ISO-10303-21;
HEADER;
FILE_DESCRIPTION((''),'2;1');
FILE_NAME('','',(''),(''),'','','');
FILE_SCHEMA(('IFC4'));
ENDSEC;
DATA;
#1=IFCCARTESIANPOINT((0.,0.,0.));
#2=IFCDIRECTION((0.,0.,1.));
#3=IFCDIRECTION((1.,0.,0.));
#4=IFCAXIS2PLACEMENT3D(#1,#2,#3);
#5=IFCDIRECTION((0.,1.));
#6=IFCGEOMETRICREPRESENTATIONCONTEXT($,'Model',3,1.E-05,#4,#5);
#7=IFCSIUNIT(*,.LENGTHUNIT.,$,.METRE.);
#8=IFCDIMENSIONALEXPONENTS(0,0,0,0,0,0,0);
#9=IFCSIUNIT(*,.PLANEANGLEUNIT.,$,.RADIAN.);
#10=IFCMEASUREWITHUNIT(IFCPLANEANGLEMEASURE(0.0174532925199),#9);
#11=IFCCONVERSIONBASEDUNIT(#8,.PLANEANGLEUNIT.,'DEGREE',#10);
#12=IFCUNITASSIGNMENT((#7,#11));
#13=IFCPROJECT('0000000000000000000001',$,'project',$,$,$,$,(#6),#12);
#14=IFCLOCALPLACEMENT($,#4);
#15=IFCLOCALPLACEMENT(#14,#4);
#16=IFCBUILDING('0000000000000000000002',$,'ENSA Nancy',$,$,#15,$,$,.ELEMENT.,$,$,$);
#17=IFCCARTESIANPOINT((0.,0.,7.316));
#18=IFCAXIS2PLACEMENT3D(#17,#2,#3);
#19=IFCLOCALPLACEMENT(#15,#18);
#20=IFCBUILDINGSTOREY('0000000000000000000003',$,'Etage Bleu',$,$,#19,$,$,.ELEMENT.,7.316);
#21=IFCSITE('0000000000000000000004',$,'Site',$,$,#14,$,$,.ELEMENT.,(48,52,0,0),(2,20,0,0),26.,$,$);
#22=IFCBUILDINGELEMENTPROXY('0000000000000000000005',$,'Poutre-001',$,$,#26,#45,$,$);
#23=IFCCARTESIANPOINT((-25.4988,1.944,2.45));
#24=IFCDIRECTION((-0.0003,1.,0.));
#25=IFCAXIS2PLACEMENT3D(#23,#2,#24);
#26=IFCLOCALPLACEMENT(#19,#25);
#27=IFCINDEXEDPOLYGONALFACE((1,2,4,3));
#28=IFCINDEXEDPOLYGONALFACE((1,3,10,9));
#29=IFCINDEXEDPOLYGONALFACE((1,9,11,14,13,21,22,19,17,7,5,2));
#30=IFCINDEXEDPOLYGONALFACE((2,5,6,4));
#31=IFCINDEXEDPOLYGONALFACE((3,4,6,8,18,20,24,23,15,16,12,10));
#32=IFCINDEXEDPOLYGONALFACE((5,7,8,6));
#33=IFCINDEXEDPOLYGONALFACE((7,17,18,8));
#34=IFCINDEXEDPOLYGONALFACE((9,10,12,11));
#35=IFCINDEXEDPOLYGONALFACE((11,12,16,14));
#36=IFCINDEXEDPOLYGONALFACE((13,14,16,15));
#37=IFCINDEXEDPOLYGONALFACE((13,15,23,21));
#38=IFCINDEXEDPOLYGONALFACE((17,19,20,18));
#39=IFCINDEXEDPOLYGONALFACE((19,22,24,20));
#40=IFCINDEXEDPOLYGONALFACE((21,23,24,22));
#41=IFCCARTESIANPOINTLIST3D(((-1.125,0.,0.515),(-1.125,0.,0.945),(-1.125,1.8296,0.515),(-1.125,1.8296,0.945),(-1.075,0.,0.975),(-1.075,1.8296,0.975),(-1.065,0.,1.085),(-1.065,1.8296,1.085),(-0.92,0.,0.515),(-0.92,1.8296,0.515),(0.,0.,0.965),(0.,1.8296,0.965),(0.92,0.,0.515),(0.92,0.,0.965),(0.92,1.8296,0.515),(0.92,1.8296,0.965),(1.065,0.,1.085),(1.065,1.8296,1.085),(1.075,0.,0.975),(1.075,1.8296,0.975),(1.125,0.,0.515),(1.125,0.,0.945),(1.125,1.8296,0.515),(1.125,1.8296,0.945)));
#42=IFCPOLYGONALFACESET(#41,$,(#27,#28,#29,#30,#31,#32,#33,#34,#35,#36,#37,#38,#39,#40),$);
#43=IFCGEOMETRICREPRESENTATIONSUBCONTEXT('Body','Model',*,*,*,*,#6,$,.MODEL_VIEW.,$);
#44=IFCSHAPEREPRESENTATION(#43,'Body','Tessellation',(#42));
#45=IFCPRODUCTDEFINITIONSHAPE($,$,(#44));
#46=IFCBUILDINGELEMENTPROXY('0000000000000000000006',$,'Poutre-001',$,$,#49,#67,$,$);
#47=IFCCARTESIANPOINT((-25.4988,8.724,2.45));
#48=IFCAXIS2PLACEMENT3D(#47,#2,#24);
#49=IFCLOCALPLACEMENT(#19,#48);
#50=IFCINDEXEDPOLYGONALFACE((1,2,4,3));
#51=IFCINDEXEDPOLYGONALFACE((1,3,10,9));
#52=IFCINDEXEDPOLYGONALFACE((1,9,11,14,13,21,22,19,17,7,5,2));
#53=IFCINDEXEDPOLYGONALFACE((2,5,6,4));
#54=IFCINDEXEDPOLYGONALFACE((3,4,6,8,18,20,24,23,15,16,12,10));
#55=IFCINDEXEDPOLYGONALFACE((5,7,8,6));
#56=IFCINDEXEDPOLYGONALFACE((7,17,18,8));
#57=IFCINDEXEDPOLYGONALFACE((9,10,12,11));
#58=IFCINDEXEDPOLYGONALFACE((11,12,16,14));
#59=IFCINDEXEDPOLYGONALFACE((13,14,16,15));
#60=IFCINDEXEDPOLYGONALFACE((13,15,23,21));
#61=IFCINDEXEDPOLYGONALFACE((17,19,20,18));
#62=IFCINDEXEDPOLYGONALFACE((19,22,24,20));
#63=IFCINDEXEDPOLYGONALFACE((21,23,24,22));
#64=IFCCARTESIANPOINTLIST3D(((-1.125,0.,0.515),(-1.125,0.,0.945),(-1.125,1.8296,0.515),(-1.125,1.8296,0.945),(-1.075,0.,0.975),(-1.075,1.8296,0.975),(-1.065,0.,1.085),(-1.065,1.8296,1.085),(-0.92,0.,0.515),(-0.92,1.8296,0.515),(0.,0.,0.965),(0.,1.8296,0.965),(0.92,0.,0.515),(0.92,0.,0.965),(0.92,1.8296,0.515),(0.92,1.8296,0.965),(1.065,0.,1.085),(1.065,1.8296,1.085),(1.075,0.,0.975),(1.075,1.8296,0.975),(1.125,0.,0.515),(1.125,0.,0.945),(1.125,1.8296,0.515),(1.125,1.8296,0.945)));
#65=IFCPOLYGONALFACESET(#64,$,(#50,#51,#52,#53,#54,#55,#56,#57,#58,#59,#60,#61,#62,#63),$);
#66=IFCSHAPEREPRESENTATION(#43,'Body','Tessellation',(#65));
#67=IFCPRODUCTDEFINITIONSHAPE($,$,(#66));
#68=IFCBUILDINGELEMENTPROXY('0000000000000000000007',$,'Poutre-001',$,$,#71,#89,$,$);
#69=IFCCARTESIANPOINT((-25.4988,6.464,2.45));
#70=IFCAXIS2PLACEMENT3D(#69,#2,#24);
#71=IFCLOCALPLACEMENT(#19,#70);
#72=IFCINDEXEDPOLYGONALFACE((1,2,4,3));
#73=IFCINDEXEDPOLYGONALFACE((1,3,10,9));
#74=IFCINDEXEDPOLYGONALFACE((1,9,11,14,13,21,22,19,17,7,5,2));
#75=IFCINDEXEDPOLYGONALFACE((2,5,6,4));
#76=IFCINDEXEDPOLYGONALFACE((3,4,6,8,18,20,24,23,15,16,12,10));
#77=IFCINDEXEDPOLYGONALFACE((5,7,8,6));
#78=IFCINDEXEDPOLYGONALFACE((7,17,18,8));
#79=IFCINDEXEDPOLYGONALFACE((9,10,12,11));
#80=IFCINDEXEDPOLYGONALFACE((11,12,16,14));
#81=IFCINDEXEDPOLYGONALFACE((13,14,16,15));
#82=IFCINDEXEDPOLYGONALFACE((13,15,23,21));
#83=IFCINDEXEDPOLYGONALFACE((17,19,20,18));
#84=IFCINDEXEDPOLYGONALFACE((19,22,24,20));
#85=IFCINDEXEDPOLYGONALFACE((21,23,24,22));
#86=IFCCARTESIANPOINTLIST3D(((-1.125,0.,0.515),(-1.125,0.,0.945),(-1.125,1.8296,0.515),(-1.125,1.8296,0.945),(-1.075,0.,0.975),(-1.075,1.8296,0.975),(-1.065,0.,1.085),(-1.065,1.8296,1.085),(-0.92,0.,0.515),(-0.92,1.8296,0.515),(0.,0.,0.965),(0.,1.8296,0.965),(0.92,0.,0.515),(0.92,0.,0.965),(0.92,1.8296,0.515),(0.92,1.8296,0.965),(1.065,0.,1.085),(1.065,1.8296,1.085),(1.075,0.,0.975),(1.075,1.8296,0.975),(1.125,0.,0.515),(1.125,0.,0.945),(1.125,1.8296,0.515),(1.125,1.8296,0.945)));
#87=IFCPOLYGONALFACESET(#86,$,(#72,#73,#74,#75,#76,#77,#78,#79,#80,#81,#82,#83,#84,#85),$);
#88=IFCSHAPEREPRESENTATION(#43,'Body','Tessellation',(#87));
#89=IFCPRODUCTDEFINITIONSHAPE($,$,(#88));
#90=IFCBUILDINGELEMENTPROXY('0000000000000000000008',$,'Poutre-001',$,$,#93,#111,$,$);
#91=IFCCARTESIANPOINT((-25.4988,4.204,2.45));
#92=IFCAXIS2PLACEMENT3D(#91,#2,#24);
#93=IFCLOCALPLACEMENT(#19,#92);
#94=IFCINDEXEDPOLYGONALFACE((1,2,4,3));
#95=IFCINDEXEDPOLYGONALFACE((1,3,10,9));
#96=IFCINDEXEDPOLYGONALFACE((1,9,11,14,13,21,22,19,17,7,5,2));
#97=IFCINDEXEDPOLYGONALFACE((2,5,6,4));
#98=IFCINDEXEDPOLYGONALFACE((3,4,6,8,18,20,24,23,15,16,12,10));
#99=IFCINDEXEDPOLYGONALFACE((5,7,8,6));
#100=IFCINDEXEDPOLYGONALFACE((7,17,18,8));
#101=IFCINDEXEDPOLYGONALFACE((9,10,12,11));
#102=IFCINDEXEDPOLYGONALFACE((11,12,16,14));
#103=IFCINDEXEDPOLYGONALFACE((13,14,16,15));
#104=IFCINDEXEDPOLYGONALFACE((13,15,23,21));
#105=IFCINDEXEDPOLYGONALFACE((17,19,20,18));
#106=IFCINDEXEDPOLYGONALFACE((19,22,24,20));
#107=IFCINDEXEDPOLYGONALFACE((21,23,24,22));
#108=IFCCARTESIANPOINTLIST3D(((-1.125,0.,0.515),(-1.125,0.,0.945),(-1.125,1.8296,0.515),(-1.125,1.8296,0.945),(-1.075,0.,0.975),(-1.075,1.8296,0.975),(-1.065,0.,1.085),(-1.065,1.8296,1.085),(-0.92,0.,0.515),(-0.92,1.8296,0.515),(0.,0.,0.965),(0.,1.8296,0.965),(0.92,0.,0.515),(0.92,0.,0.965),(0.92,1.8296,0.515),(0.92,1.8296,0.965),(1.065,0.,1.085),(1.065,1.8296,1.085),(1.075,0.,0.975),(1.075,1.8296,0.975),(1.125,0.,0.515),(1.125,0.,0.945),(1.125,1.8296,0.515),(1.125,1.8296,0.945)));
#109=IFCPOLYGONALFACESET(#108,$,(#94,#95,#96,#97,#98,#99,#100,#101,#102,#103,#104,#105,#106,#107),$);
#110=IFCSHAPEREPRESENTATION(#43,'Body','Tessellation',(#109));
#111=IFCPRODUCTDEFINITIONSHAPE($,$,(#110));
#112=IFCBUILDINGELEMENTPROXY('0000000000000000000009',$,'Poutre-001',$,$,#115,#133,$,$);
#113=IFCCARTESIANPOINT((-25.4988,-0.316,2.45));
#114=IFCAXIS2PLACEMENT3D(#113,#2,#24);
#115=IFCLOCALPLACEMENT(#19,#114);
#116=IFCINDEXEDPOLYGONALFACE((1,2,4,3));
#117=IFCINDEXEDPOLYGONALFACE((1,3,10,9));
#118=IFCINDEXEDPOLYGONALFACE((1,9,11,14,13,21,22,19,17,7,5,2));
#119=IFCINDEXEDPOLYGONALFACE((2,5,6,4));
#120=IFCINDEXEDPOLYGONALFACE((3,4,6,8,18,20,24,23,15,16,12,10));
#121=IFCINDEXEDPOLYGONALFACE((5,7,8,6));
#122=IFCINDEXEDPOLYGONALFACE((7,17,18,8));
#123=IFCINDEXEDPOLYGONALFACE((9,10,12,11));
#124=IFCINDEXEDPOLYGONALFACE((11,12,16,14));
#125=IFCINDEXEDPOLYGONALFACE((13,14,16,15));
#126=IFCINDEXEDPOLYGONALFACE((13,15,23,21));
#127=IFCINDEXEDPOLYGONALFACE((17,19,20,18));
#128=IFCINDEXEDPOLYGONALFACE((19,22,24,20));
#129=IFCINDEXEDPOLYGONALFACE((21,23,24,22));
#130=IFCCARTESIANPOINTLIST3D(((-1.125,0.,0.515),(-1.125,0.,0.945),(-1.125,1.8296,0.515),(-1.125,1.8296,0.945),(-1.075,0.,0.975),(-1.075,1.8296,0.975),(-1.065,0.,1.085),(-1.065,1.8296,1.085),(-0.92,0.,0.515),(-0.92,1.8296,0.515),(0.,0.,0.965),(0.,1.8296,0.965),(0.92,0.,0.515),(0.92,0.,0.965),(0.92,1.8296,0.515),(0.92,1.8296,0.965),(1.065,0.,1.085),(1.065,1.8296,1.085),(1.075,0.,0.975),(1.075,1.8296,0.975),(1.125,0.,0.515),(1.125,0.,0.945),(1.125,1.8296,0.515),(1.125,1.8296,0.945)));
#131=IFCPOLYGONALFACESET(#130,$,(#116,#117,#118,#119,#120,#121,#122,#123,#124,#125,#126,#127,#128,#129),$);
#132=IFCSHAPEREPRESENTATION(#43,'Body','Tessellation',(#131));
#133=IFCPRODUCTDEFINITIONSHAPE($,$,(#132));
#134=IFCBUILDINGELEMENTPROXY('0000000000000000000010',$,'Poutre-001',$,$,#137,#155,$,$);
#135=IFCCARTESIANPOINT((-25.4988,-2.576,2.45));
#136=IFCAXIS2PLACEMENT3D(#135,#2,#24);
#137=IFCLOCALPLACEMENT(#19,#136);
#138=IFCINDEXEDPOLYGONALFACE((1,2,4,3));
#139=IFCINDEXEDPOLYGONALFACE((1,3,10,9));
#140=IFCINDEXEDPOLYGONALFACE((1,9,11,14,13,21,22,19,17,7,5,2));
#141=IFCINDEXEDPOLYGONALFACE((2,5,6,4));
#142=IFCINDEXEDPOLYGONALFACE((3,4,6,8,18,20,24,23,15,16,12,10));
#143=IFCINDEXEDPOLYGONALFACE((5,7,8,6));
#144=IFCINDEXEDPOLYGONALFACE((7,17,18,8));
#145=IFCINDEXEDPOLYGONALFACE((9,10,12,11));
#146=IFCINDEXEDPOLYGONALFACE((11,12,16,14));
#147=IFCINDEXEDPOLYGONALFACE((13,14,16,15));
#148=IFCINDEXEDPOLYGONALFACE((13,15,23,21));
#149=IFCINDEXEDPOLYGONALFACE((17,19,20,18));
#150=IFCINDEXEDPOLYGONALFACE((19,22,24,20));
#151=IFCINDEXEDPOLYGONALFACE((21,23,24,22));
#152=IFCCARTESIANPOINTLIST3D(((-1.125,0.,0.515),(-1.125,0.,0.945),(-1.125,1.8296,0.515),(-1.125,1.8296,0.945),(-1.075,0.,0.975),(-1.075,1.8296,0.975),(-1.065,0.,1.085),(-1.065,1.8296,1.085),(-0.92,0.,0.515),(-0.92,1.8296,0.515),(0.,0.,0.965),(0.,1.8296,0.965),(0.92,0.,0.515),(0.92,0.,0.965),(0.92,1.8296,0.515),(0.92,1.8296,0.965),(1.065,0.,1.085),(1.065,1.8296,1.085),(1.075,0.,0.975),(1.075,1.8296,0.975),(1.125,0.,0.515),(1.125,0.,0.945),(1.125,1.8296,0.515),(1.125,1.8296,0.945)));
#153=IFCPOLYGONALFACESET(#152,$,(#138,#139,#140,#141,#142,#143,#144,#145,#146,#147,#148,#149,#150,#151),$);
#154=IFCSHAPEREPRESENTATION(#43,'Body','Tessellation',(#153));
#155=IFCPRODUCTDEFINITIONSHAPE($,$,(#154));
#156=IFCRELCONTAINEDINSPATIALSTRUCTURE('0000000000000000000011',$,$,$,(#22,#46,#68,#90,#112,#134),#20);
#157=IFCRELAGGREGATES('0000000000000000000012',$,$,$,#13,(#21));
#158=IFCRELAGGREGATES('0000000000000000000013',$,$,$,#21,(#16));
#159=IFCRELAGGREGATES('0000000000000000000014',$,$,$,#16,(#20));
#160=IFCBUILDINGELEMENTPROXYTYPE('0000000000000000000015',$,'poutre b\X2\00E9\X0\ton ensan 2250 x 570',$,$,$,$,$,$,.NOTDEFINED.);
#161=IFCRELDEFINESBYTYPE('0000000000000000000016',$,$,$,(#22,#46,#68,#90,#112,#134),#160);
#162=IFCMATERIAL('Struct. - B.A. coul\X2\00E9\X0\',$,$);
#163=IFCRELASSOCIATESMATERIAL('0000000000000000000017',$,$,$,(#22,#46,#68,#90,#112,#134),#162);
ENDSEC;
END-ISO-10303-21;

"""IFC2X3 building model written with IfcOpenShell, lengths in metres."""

from ifc_helpers import new_model, entity, si_unit, converted_unit, direction, frame, origin_with_axes, place, context, subcontext, project, spatial, polyline, outline, extrude, material, type_object, element, save


model = new_model("IFC2X3")

# Units and contexts
model_context = context("Model", 3, precision=1e-05, world=origin_with_axes(), true_north=direction((0.0, 1.0)))
body_context = subcontext(model_context, "Body", "Model", "MODEL_VIEW")
ifc_project = project(units=[si_unit("LENGTHUNIT", "METRE"), converted_unit("PLANEANGLEUNIT", "DEGREE", entity("IfcPlaneAngleMeasure", 0.0174532925199), si_unit("PLANEANGLEUNIT", "RADIAN"), dimensions=[0, 0, 0, 0, 0, 0, 0])], contexts=[model_context])

# Site, building, storey
site_placement = place(None, origin_with_axes())
site = spatial("IfcSite", under=ifc_project, at=site_placement, Name="Site", CompositionType="ELEMENT", RefLatitude=(48, 52, 0, 0), RefLongitude=(2, 20, 0, 0), RefElevation=26.0)
building_placement = place(site_placement, origin_with_axes())
building = spatial("IfcBuilding", under=site, at=building_placement, Name="ENSA Nancy", CompositionType="ELEMENT")
storey_placement = place(building_placement, frame((0.0, 0.0, 7.316), z_axis=(0.0, 0.0, 1.0), x_axis=(1.0, 0.0, 0.0)))
storey = spatial("IfcBuildingStorey", under=building, at=storey_placement, Name="Etage Bleu", CompositionType="ELEMENT", Elevation=7.316)

# Building element proxies
ifc_material_1 = material(Name="Struct. - B.A. coulé")
building_element_proxy_type_1 = type_object("IfcBuildingElementProxyType", Name="poutre béton ensan 2250 x 570", PredefinedType="NOTDEFINED")
for number, where, z_axis, x_axis, name in (
    (1, (-25.4988, 1.944, 2.45), (0.0, 0.0, 1.0), (-0.0003, 1.0, 0.0), "Poutre-001"),
    (2, (-25.4988, 8.724, 2.45), (0.0, 0.0, 1.0), (-0.0003, 1.0, 0.0), "Poutre-001"),
    (3, (-25.4988, 6.464, 2.45), (0.0, 0.0, 1.0), (-0.0003, 1.0, 0.0), "Poutre-001"),
    (4, (-25.4988, 4.204, 2.45), (0.0, 0.0, 1.0), (-0.0003, 1.0, 0.0), "Poutre-001"),
    (5, (-25.4988, -0.316, 2.45), (0.0, 0.0, 1.0), (-0.0003, 1.0, 0.0), "Poutre-001"),
    (6, (-25.4988, -2.576, 2.45), (0.0, 0.0, 1.0), (-0.0003, 1.0, 0.0), "Poutre-001"),
):
    element("IfcBuildingElementProxy", number, at=place(storey_placement, frame(where, z_axis=z_axis, x_axis=x_axis)), inside=storey, type_object=building_element_proxy_type_1, material=ifc_material_1, Name=name, context=body_context, shape_type="SweptSolid", body=[
        extrude(outline(polyline([(-1.065, 1.085), (-1.075, 0.975), (-1.125, 0.945), (-1.125, 0.515), (-0.92, 0.515), (0.0, 0.965), (0.92, 0.965), (0.92, 0.515), (1.125, 0.515), (1.125, 0.945), (1.075, 0.975), (1.065, 1.085), (-1.065, 1.085)])), frame((0.0, 1.8296, 0.0), z_axis=(0.0, -1.0, 0.0), x_axis=(1.0, 0.0, 0.0)), (0.0, 0.0, 1.0), 1.8296),
    ])

save(model, "model.ifc")
